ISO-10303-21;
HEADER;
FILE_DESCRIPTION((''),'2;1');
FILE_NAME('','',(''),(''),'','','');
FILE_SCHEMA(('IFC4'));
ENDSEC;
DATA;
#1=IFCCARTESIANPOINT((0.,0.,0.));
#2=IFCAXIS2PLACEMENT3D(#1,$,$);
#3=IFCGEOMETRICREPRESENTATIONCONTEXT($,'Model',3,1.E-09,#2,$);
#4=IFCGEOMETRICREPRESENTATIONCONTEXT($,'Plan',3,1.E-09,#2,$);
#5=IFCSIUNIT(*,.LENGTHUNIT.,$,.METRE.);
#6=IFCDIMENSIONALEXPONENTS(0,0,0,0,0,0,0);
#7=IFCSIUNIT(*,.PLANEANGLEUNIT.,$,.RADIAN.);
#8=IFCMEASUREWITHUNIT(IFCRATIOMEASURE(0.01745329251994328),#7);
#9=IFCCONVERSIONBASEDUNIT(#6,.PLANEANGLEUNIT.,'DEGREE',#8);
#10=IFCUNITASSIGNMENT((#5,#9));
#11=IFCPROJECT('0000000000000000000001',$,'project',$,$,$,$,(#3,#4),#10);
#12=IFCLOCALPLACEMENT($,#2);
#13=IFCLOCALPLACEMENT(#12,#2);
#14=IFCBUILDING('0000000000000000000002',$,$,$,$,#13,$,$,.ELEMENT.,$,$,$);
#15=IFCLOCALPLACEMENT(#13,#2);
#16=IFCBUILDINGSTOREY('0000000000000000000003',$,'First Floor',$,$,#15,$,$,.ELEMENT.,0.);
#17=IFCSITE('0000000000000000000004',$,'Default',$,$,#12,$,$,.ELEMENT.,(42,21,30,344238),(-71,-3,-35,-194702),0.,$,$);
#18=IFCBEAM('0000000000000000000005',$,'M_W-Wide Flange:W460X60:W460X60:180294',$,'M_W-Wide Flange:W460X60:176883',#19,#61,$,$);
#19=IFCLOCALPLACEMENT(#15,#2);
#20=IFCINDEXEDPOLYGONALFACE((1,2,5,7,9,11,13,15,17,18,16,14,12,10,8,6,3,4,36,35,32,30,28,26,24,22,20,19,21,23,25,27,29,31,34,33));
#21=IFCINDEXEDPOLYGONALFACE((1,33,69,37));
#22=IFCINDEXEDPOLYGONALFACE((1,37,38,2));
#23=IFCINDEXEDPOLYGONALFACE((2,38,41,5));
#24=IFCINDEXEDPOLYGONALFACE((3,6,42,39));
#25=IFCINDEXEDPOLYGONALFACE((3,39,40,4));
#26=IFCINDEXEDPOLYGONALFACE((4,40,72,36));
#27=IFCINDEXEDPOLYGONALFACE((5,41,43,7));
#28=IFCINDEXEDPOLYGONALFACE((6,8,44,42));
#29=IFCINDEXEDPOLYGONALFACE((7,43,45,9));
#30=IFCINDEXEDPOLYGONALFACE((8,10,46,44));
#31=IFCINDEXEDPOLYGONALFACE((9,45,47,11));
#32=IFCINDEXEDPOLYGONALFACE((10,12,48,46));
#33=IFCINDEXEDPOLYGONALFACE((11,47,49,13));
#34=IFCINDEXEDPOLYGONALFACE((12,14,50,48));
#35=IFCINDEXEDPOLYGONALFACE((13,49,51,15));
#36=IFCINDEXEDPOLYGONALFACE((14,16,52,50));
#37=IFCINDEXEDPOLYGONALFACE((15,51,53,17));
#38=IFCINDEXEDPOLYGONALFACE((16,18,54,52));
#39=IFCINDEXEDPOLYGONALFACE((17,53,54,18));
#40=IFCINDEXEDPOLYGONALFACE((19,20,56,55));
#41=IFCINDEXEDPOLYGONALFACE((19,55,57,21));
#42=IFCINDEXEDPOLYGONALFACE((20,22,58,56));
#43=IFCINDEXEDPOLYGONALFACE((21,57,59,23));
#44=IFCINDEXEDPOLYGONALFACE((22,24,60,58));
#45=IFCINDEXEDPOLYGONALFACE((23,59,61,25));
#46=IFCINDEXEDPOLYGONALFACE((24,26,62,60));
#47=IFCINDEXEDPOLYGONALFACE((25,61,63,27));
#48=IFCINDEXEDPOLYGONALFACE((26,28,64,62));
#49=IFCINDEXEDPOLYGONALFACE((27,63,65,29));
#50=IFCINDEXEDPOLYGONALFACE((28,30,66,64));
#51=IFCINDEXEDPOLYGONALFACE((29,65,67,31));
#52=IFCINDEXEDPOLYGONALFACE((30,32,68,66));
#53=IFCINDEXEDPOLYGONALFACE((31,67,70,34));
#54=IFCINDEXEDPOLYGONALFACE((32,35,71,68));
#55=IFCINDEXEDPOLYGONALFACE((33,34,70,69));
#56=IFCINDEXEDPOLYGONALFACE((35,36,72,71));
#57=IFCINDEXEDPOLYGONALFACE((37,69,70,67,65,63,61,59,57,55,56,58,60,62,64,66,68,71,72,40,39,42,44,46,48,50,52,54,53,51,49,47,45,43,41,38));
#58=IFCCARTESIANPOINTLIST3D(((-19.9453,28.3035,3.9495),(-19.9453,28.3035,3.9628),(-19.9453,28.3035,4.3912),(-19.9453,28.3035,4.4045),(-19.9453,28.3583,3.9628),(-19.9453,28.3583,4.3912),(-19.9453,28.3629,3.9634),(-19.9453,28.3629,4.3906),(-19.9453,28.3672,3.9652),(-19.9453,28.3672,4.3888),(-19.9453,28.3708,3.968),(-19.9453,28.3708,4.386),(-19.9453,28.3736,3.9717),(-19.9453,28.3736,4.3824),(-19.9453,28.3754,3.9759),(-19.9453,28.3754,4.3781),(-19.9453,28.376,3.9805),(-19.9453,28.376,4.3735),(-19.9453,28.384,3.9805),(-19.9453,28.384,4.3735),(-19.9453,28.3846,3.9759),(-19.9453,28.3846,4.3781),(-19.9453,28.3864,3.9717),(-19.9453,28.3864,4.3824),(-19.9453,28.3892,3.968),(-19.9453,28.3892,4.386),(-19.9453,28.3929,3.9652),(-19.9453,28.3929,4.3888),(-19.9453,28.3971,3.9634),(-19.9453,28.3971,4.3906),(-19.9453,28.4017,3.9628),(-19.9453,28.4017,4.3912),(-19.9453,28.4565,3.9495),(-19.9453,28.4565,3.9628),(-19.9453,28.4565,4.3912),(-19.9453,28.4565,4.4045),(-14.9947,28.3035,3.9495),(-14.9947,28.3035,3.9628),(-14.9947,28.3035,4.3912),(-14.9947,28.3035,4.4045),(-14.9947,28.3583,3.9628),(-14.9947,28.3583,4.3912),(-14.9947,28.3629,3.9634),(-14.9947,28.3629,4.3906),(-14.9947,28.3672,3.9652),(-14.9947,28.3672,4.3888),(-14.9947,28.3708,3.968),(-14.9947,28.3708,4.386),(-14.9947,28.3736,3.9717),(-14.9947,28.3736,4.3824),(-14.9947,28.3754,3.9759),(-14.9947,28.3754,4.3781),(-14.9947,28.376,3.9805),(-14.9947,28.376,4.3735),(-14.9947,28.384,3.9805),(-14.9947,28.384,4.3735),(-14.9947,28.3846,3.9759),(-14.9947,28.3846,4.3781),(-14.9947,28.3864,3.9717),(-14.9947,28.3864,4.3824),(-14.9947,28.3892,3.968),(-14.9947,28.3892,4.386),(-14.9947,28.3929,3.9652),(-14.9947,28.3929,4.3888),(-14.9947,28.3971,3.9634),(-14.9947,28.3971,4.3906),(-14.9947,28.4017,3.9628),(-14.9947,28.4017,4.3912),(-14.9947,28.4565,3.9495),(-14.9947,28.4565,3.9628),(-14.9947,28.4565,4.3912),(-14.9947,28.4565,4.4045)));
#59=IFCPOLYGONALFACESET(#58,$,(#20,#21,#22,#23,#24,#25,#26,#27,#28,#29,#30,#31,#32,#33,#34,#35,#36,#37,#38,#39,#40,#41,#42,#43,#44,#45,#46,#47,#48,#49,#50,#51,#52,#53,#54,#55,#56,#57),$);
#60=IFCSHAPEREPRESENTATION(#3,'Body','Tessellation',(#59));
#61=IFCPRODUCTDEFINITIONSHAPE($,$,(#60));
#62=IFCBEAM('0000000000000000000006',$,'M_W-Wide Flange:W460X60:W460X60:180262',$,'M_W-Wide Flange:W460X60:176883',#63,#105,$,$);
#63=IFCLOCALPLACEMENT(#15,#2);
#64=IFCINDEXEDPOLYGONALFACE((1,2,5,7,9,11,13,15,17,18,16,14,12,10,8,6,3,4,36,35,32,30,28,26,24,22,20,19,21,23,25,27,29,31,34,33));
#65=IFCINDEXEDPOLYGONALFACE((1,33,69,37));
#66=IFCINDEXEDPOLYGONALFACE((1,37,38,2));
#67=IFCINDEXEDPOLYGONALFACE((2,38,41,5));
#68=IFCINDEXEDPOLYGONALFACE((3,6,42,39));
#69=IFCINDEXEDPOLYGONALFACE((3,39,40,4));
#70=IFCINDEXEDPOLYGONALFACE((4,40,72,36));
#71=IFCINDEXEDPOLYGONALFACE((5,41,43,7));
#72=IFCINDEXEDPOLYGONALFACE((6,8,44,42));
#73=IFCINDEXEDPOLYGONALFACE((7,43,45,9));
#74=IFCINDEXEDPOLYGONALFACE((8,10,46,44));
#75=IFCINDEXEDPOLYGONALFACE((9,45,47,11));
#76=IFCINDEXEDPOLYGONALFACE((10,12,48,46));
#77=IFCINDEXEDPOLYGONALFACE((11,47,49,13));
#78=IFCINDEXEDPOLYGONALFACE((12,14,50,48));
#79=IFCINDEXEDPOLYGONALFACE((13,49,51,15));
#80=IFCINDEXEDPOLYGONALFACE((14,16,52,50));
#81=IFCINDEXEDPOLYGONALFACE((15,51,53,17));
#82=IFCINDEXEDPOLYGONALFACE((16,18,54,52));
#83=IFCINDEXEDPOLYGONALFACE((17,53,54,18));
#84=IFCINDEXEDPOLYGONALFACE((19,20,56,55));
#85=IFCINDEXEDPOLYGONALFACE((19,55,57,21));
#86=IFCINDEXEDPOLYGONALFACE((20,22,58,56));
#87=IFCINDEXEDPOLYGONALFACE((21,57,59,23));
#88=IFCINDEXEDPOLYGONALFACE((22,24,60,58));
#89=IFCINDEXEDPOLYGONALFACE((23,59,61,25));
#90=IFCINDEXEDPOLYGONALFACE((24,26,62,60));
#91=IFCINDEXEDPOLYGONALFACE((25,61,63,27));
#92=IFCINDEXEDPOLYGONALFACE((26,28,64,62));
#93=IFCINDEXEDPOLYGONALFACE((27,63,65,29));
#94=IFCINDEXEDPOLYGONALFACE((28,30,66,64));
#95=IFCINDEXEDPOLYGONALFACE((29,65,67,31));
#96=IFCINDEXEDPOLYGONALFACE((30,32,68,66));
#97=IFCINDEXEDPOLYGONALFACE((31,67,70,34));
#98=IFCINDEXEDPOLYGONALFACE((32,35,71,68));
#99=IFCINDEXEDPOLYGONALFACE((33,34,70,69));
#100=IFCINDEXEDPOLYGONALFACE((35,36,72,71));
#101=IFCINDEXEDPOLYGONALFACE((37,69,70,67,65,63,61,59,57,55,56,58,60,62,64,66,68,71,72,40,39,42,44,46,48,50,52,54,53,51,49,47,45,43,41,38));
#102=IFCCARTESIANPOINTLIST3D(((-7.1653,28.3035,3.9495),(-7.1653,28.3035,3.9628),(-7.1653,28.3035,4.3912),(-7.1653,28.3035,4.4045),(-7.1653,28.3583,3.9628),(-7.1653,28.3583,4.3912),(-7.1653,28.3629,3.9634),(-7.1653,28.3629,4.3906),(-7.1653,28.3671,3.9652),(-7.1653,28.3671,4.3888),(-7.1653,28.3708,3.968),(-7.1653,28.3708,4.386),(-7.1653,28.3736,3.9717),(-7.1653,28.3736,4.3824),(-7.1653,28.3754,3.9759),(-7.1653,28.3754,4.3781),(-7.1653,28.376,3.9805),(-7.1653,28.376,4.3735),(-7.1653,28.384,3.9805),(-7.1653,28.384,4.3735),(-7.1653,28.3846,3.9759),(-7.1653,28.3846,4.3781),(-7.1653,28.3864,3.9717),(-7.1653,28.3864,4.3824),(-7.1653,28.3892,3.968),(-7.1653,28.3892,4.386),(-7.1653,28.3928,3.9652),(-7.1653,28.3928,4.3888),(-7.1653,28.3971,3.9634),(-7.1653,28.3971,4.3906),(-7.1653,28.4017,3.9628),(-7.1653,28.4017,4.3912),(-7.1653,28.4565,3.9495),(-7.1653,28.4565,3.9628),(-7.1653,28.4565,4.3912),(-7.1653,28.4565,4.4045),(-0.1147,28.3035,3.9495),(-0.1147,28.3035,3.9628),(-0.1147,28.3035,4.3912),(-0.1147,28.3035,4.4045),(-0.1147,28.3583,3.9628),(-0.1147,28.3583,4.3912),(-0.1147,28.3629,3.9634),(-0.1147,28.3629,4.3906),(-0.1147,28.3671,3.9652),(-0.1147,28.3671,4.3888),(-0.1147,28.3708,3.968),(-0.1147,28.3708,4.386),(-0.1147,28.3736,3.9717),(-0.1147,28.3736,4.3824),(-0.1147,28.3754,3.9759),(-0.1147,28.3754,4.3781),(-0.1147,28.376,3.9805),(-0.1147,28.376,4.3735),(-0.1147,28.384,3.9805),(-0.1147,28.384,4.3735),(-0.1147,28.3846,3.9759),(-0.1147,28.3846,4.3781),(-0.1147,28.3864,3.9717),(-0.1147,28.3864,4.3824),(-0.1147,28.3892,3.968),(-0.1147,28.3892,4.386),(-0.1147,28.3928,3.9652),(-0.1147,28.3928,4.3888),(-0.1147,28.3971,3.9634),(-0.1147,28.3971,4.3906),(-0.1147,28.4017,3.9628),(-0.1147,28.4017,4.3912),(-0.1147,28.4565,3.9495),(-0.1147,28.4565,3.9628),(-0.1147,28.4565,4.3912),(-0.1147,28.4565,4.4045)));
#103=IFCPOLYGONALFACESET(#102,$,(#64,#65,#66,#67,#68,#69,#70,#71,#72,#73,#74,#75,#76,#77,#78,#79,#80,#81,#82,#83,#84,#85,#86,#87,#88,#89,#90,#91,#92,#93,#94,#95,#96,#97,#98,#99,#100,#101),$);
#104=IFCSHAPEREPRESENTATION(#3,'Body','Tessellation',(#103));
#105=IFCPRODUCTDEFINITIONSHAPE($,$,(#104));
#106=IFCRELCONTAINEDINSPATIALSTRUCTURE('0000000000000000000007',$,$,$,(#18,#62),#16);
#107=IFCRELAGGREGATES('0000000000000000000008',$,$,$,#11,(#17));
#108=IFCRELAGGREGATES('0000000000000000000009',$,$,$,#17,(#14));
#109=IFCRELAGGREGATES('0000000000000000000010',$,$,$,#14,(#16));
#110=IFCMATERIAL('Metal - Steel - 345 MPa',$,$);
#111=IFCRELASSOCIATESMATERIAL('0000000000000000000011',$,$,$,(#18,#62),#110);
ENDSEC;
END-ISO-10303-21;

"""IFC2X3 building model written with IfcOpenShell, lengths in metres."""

from ifc_helpers import new_model, entity, si_unit, converted_unit, frame, frame_2d, origin, place, context, project, spatial, polyline, circle_curve, parameter, trimmed, segment, composite_curve, outline, extrude, material, element, save


model = new_model("IFC2X3")

# Units and contexts
model_context = context("Model", 3, precision=1e-09, world=origin())
plan_context = context("Plan", 3, precision=1e-09, world=origin())
ifc_project = project(units=[si_unit("LENGTHUNIT", "METRE"), converted_unit("PLANEANGLEUNIT", "DEGREE", entity("IfcRatioMeasure", 0.01745329251994328), si_unit("PLANEANGLEUNIT", "RADIAN"), dimensions=[0, 0, 0, 0, 0, 0, 0])], contexts=[model_context, plan_context])

# Site, building, storey
site_placement = place(None, origin())
site = spatial("IfcSite", under=ifc_project, at=site_placement, Name="Default", CompositionType="ELEMENT", RefLatitude=(42, 21, 30, 344238), RefLongitude=(-71, -3, -35, -194702), RefElevation=0.0)
building_placement = place(site_placement, origin())
building = spatial("IfcBuilding", under=site, at=building_placement, CompositionType="ELEMENT")
storey_placement = place(building_placement, origin())
storey = spatial("IfcBuildingStorey", under=building, at=storey_placement, Name="First Floor", CompositionType="ELEMENT", Elevation=0.0)

# Shared definitions
ifc_material = material(Name="Metal - Steel - 345 MPa")

# Beams
beam_1_placement = place(storey_placement, frame((-14.8773, 28.38, 4.4045), z_axis=(0.0, 0.0, 1.0), x_axis=(0.0, 1.0, 0.0)))
element("IfcBeam", 1, at=beam_1_placement, inside=storey, material=ifc_material, Name="M_W-Wide Flange:W460X60:W460X60:180294", ObjectType="M_W-Wide Flange:W460X60:176883", context=model_context, shape_type="SweptSolid", body=[
    extrude(outline(composite_curve([segment(polyline([(0.2142, -0.0765), (0.2275, -0.0765)]), True, "CONTINUOUS"), segment(polyline([(0.2275, -0.0765), (0.2275, 0.0765)]), True, "CONTINUOUS"), segment(polyline([(0.2275, 0.0765), (0.2142, 0.0765)]), True, "CONTINUOUS"), segment(polyline([(0.2142, 0.0765), (0.2142, 0.0217)]), True, "CONTINUOUS"), segment(trimmed(circle_curve(frame_2d((0.1965, 0.0217), x_axis=(1.0, 0.0)), 0.0177), [parameter(270.0)], [parameter(360.0)], True, "PARAMETER"), False, "CONTINUOUS"), segment(polyline([(0.1965, 0.004), (-0.1965, 0.004)]), True, "CONTINUOUS"), segment(trimmed(circle_curve(frame_2d((-0.1965, 0.0217), x_axis=(0.0, -1.0)), 0.0177), [parameter(270.0)], [parameter(360.0)], True, "PARAMETER"), False, "CONTINUOUS"), segment(polyline([(-0.2142, 0.0217), (-0.2142, 0.0765)]), True, "CONTINUOUS"), segment(polyline([(-0.2142, 0.0765), (-0.2275, 0.0765)]), True, "CONTINUOUS"), segment(polyline([(-0.2275, 0.0765), (-0.2275, -0.0765)]), True, "CONTINUOUS"), segment(polyline([(-0.2275, -0.0765), (-0.2142, -0.0765)]), True, "CONTINUOUS"), segment(polyline([(-0.2142, -0.0765), (-0.2142, -0.0217)]), True, "CONTINUOUS"), segment(trimmed(circle_curve(frame_2d((-0.1965, -0.0217), x_axis=(-1.0, 0.0)), 0.0177), [parameter(270.0)], [parameter(360.0)], True, "PARAMETER"), False, "CONTINUOUS"), segment(polyline([(-0.1965, -0.004), (0.1965, -0.004)]), True, "CONTINUOUS"), segment(trimmed(circle_curve(frame_2d((0.1965, -0.0217), x_axis=(0.0, 1.0)), 0.0177), [parameter(270.0)], [parameter(0.0)], True, "PARAMETER"), False, "CONTINUOUS"), segment(polyline([(0.2142, -0.0217), (0.2142, -0.0765)]), True, "CONTINUOUS")], self_intersect=False)), frame((0.0, 5.068, -0.2275), z_axis=(0.0, -1.0, 0.0), x_axis=(0.0, 0.0, -1.0)), (0.0, 0.0, 1.0), 4.9506),
])
beam_2_placement = place(storey_placement, frame((0.0019, 28.38, 4.4045), z_axis=(0.0, 0.0, 1.0), x_axis=(0.0, 1.0, 0.0)))
element("IfcBeam", 2, at=beam_2_placement, inside=storey, material=ifc_material, Name="M_W-Wide Flange:W460X60:W460X60:180262", ObjectType="M_W-Wide Flange:W460X60:176883", context=model_context, shape_type="SweptSolid", body=[
    extrude(outline(composite_curve([segment(polyline([(0.2142, -0.0765), (0.2275, -0.0765)]), True, "CONTINUOUS"), segment(polyline([(0.2275, -0.0765), (0.2275, 0.0765)]), True, "CONTINUOUS"), segment(polyline([(0.2275, 0.0765), (0.2142, 0.0765)]), True, "CONTINUOUS"), segment(polyline([(0.2142, 0.0765), (0.2142, 0.0217)]), True, "CONTINUOUS"), segment(trimmed(circle_curve(frame_2d((0.1965, 0.0217), x_axis=(1.0, 0.0)), 0.0177), [parameter(270.0)], [parameter(360.0)], True, "PARAMETER"), False, "CONTINUOUS"), segment(polyline([(0.1965, 0.004), (-0.1965, 0.004)]), True, "CONTINUOUS"), segment(trimmed(circle_curve(frame_2d((-0.1965, 0.0217), x_axis=(0.0, -1.0)), 0.0177), [parameter(270.0)], [parameter(360.0)], True, "PARAMETER"), False, "CONTINUOUS"), segment(polyline([(-0.2142, 0.0217), (-0.2142, 0.0765)]), True, "CONTINUOUS"), segment(polyline([(-0.2142, 0.0765), (-0.2275, 0.0765)]), True, "CONTINUOUS"), segment(polyline([(-0.2275, 0.0765), (-0.2275, -0.0765)]), True, "CONTINUOUS"), segment(polyline([(-0.2275, -0.0765), (-0.2142, -0.0765)]), True, "CONTINUOUS"), segment(polyline([(-0.2142, -0.0765), (-0.2142, -0.0217)]), True, "CONTINUOUS"), segment(trimmed(circle_curve(frame_2d((-0.1965, -0.0217), x_axis=(-1.0, 0.0)), 0.0177), [parameter(270.0)], [parameter(360.0)], True, "PARAMETER"), False, "CONTINUOUS"), segment(polyline([(-0.1965, -0.004), (0.1965, -0.004)]), True, "CONTINUOUS"), segment(trimmed(circle_curve(frame_2d((0.1965, -0.0217), x_axis=(0.0, 1.0)), 0.0177), [parameter(270.0)], [parameter(0.0)], True, "PARAMETER"), False, "CONTINUOUS"), segment(polyline([(0.2142, -0.0217), (0.2142, -0.0765)]), True, "CONTINUOUS")], self_intersect=False)), frame((0.0, 7.1672, -0.2275), z_axis=(0.0, -1.0, 0.0), x_axis=(0.0, 0.0, -1.0)), (0.0, 0.0, 1.0), 7.0506),
])

save(model, "model.ifc")
